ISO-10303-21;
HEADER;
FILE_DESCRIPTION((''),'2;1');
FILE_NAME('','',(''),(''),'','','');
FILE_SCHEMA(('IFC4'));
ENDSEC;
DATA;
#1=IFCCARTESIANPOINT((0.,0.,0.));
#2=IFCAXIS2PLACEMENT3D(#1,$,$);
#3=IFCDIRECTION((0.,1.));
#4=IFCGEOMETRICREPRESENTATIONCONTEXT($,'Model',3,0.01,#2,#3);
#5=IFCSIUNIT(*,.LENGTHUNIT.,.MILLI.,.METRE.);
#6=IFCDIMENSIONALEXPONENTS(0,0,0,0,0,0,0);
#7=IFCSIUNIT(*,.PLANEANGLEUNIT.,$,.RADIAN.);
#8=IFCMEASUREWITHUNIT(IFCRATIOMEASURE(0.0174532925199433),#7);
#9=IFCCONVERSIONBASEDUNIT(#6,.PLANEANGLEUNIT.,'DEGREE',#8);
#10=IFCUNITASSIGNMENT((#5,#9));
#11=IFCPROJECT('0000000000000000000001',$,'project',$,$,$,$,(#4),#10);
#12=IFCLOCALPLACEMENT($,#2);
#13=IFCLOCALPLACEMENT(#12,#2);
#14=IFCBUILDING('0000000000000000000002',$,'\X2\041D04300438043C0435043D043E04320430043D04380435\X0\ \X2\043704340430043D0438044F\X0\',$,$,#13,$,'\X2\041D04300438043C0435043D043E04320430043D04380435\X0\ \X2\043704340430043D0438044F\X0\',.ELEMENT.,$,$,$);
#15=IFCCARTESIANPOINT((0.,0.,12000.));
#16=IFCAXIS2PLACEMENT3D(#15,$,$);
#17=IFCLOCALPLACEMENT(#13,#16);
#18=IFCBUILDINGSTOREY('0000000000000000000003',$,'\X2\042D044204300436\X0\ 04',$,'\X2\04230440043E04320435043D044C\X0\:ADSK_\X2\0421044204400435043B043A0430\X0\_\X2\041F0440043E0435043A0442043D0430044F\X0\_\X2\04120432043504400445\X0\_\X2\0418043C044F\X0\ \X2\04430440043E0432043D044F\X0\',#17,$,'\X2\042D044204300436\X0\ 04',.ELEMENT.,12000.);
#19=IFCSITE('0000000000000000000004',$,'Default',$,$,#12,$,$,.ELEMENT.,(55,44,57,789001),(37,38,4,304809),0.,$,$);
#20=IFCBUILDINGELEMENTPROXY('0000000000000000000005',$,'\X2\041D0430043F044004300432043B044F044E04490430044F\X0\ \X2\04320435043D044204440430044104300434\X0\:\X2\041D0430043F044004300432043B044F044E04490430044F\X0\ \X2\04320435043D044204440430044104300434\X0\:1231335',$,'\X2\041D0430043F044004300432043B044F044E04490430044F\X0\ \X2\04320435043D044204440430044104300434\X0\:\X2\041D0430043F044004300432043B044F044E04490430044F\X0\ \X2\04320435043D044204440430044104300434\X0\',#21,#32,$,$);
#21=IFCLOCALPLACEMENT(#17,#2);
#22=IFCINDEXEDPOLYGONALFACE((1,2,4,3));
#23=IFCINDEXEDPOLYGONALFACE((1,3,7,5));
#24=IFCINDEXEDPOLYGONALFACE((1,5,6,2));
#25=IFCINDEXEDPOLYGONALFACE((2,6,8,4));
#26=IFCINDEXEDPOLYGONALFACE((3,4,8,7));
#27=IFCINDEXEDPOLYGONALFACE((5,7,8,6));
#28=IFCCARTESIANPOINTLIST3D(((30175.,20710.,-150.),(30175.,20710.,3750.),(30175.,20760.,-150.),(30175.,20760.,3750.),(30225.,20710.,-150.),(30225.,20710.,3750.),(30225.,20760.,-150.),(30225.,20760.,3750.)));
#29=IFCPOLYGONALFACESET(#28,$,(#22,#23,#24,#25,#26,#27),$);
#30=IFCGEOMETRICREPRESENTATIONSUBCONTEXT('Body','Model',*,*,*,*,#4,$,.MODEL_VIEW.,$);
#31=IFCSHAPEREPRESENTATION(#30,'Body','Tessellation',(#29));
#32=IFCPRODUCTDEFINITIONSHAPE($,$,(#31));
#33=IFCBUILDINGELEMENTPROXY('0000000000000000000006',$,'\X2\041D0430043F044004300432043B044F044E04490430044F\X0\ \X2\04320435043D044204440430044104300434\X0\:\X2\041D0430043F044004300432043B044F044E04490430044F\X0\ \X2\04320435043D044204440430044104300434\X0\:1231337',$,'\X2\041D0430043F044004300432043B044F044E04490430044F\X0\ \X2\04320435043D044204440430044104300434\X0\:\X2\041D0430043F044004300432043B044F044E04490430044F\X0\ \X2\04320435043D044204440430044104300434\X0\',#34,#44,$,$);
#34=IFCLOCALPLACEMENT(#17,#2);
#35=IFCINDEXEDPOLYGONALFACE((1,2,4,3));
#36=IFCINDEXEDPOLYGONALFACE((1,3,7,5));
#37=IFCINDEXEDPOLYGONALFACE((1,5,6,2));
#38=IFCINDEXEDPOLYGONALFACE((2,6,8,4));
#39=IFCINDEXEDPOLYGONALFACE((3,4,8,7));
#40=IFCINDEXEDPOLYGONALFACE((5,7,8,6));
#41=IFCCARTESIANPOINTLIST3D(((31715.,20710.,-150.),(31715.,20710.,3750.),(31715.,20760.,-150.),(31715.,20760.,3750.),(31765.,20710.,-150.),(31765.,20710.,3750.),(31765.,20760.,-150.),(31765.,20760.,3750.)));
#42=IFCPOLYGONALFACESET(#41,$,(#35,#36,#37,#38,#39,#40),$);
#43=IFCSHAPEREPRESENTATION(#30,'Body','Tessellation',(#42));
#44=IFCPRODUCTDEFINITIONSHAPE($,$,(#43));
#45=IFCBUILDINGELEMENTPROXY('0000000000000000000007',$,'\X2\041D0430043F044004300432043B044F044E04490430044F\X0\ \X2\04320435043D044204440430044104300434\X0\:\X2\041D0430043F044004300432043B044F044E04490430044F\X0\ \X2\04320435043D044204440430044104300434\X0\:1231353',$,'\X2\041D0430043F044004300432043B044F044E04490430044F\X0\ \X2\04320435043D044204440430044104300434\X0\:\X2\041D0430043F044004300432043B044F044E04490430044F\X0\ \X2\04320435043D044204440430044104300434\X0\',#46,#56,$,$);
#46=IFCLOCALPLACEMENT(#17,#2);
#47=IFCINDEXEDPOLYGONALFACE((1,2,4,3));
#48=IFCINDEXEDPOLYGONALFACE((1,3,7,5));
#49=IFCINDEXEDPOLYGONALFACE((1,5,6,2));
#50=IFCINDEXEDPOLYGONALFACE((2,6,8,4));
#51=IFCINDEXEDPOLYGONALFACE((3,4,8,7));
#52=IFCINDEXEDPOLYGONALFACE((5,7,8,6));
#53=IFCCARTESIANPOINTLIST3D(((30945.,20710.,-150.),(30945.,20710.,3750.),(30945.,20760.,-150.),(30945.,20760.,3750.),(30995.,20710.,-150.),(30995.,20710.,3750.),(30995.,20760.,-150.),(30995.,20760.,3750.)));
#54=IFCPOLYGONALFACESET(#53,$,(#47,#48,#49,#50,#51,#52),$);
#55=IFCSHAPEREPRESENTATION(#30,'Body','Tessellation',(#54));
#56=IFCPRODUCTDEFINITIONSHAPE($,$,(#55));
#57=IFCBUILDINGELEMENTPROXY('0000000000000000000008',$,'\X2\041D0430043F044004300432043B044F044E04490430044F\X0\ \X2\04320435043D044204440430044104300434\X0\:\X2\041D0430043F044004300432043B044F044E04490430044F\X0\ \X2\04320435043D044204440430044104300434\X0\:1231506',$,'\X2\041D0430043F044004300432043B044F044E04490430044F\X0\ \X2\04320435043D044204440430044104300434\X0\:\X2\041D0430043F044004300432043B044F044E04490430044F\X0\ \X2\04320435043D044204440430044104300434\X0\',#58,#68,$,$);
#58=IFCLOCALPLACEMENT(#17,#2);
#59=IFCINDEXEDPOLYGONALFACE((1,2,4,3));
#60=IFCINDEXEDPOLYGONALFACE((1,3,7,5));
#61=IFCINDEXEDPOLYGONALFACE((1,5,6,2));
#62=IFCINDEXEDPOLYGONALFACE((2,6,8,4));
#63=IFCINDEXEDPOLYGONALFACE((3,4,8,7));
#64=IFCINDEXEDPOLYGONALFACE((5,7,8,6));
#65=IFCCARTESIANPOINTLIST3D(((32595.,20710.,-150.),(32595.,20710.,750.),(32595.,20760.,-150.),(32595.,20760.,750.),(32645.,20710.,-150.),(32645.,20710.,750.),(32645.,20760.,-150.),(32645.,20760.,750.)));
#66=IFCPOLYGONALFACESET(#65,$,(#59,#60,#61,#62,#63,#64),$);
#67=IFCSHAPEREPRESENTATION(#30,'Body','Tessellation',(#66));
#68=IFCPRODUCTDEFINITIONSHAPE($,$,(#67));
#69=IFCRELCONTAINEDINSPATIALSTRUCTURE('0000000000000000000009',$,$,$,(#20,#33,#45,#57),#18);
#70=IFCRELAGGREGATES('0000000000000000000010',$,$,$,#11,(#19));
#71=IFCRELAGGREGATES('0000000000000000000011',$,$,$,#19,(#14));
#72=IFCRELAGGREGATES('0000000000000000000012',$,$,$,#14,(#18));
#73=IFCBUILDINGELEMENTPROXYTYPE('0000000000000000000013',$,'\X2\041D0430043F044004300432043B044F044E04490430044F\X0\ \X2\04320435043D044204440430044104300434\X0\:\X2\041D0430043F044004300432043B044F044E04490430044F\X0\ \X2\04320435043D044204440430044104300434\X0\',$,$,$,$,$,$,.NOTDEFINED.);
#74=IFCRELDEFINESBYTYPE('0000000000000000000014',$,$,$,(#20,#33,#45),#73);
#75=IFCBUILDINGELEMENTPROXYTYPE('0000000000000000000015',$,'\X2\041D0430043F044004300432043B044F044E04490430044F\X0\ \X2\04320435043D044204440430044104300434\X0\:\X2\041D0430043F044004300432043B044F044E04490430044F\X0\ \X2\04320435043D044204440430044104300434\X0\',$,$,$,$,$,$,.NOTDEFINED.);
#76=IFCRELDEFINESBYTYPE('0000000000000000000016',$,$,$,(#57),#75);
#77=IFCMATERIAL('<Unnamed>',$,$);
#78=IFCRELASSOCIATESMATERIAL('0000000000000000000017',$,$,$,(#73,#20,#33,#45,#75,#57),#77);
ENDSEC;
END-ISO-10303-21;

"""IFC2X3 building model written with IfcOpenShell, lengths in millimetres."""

from ifc_helpers import new_model, entity, si_unit, converted_unit, direction, frame, origin, origin_2d_with_axis, place, context, subcontext, project, spatial, rectangle, extrude, source, transform, mapped, material, type_object, type_shapes, element, save


model = new_model("IFC2X3")

# Units and contexts
model_context = context("Model", 3, precision=0.01, world=origin(), true_north=direction((0.0, 1.0)))
body_context = subcontext(model_context, "Body", "Model", "MODEL_VIEW")
ifc_project = project(units=[si_unit("LENGTHUNIT", "METRE", prefix="MILLI"), converted_unit("PLANEANGLEUNIT", "DEGREE", entity("IfcRatioMeasure", 0.0174532925199433), si_unit("PLANEANGLEUNIT", "RADIAN"), dimensions=[0, 0, 0, 0, 0, 0, 0])], contexts=[model_context])

# Site, building, storey
site_placement = place(None, origin())
site = spatial("IfcSite", under=ifc_project, at=site_placement, Name="Default", CompositionType="ELEMENT", RefLatitude=(55, 44, 57, 789001), RefLongitude=(37, 38, 4, 304809), RefElevation=0.0)
building_placement = place(site_placement, origin())
building = spatial("IfcBuilding", under=site, at=building_placement, Name="Наименование здания", LongName="Наименование здания", CompositionType="ELEMENT")
storey_placement = place(building_placement, frame((0.0, 0.0, 12000.0)))
storey = spatial("IfcBuildingStorey", under=building, at=storey_placement, Name="Этаж 04", ObjectType="Уровень:ADSK_Стрелка_Проектная_Вверх_Имя уровня", LongName="Этаж 04", CompositionType="ELEMENT", Elevation=12000.0)

# Building element proxies
ifc_material_1 = material(Name="<Unnamed>")
building_element_proxy_type_1 = type_object("IfcBuildingElementProxyType", Name="Направляющая вентфасад:Направляющая вентфасад", PredefinedType="NOTDEFINED", material=ifc_material_1)
shared_shape_1 = source(origin(), body_context, "Body", "SweptSolid", [
    extrude(rectangle(XDim=50.0, YDim=50.0, at=origin_2d_with_axis()), frame((25.0, -25.0, 0.0), z_axis=(0.0, 0.0, 1.0), x_axis=(-1.0, 0.0, 0.0)), (0.0, 0.0, 1.0), 3900.0),
])
type_shapes(building_element_proxy_type_1, [shared_shape_1])
for number, where, z_axis, x_axis, name in (
    (1, (30225.0, 20710.0, -150.0), (0.0, 0.0, 1.0), (-1.0, 0.0, 0.0), "Направляющая вентфасад:Направляющая вентфасад:1231335"),
    (2, (31765.0, 20710.0, -150.0), (0.0, 0.0, 1.0), (-1.0, 0.0, 0.0), "Направляющая вентфасад:Направляющая вентфасад:1231337"),
    (3, (30995.0, 20710.0, -150.0), (0.0, 0.0, 1.0), (-1.0, 0.0, 0.0), "Направляющая вентфасад:Направляющая вентфасад:1231353"),
):
    element("IfcBuildingElementProxy", number, at=place(storey_placement, frame(where, z_axis=z_axis, x_axis=x_axis)), inside=storey, type_object=building_element_proxy_type_1, material=ifc_material_1, Name=name, ObjectType="Направляющая вентфасад:Направляющая вентфасад", context=body_context, shape_type="MappedRepresentation", body=[
        mapped(shared_shape_1, transform((0.0, 0.0, 0.0), scale=1.0)),
    ])
building_element_proxy_type_2 = type_object("IfcBuildingElementProxyType", Name="Направляющая вентфасад:Направляющая вентфасад", PredefinedType="NOTDEFINED", material=ifc_material_1)
shared_shape_2 = source(origin(), body_context, "Body", "SweptSolid", [
    extrude(rectangle(XDim=50.0, YDim=50.0, at=origin_2d_with_axis()), frame((25.0, -25.0, 0.0), z_axis=(0.0, 0.0, 1.0), x_axis=(-1.0, 0.0, 0.0)), (0.0, 0.0, 1.0), 900.0),
])
type_shapes(building_element_proxy_type_2, [shared_shape_2])
proxy_1_placement = place(storey_placement, frame((32645.0, 20710.0, -150.0), z_axis=(0.0, 0.0, 1.0), x_axis=(-1.0, 0.0, 0.0)))
element("IfcBuildingElementProxy", 4, at=proxy_1_placement, inside=storey, type_object=building_element_proxy_type_2, material=ifc_material_1, Name="Направляющая вентфасад:Направляющая вентфасад:1231506", ObjectType="Направляющая вентфасад:Направляющая вентфасад", context=body_context, shape_type="MappedRepresentation", body=[
    mapped(shared_shape_2, transform((0.0, 0.0, 0.0), scale=1.0)),
])

save(model, "model.ifc")
